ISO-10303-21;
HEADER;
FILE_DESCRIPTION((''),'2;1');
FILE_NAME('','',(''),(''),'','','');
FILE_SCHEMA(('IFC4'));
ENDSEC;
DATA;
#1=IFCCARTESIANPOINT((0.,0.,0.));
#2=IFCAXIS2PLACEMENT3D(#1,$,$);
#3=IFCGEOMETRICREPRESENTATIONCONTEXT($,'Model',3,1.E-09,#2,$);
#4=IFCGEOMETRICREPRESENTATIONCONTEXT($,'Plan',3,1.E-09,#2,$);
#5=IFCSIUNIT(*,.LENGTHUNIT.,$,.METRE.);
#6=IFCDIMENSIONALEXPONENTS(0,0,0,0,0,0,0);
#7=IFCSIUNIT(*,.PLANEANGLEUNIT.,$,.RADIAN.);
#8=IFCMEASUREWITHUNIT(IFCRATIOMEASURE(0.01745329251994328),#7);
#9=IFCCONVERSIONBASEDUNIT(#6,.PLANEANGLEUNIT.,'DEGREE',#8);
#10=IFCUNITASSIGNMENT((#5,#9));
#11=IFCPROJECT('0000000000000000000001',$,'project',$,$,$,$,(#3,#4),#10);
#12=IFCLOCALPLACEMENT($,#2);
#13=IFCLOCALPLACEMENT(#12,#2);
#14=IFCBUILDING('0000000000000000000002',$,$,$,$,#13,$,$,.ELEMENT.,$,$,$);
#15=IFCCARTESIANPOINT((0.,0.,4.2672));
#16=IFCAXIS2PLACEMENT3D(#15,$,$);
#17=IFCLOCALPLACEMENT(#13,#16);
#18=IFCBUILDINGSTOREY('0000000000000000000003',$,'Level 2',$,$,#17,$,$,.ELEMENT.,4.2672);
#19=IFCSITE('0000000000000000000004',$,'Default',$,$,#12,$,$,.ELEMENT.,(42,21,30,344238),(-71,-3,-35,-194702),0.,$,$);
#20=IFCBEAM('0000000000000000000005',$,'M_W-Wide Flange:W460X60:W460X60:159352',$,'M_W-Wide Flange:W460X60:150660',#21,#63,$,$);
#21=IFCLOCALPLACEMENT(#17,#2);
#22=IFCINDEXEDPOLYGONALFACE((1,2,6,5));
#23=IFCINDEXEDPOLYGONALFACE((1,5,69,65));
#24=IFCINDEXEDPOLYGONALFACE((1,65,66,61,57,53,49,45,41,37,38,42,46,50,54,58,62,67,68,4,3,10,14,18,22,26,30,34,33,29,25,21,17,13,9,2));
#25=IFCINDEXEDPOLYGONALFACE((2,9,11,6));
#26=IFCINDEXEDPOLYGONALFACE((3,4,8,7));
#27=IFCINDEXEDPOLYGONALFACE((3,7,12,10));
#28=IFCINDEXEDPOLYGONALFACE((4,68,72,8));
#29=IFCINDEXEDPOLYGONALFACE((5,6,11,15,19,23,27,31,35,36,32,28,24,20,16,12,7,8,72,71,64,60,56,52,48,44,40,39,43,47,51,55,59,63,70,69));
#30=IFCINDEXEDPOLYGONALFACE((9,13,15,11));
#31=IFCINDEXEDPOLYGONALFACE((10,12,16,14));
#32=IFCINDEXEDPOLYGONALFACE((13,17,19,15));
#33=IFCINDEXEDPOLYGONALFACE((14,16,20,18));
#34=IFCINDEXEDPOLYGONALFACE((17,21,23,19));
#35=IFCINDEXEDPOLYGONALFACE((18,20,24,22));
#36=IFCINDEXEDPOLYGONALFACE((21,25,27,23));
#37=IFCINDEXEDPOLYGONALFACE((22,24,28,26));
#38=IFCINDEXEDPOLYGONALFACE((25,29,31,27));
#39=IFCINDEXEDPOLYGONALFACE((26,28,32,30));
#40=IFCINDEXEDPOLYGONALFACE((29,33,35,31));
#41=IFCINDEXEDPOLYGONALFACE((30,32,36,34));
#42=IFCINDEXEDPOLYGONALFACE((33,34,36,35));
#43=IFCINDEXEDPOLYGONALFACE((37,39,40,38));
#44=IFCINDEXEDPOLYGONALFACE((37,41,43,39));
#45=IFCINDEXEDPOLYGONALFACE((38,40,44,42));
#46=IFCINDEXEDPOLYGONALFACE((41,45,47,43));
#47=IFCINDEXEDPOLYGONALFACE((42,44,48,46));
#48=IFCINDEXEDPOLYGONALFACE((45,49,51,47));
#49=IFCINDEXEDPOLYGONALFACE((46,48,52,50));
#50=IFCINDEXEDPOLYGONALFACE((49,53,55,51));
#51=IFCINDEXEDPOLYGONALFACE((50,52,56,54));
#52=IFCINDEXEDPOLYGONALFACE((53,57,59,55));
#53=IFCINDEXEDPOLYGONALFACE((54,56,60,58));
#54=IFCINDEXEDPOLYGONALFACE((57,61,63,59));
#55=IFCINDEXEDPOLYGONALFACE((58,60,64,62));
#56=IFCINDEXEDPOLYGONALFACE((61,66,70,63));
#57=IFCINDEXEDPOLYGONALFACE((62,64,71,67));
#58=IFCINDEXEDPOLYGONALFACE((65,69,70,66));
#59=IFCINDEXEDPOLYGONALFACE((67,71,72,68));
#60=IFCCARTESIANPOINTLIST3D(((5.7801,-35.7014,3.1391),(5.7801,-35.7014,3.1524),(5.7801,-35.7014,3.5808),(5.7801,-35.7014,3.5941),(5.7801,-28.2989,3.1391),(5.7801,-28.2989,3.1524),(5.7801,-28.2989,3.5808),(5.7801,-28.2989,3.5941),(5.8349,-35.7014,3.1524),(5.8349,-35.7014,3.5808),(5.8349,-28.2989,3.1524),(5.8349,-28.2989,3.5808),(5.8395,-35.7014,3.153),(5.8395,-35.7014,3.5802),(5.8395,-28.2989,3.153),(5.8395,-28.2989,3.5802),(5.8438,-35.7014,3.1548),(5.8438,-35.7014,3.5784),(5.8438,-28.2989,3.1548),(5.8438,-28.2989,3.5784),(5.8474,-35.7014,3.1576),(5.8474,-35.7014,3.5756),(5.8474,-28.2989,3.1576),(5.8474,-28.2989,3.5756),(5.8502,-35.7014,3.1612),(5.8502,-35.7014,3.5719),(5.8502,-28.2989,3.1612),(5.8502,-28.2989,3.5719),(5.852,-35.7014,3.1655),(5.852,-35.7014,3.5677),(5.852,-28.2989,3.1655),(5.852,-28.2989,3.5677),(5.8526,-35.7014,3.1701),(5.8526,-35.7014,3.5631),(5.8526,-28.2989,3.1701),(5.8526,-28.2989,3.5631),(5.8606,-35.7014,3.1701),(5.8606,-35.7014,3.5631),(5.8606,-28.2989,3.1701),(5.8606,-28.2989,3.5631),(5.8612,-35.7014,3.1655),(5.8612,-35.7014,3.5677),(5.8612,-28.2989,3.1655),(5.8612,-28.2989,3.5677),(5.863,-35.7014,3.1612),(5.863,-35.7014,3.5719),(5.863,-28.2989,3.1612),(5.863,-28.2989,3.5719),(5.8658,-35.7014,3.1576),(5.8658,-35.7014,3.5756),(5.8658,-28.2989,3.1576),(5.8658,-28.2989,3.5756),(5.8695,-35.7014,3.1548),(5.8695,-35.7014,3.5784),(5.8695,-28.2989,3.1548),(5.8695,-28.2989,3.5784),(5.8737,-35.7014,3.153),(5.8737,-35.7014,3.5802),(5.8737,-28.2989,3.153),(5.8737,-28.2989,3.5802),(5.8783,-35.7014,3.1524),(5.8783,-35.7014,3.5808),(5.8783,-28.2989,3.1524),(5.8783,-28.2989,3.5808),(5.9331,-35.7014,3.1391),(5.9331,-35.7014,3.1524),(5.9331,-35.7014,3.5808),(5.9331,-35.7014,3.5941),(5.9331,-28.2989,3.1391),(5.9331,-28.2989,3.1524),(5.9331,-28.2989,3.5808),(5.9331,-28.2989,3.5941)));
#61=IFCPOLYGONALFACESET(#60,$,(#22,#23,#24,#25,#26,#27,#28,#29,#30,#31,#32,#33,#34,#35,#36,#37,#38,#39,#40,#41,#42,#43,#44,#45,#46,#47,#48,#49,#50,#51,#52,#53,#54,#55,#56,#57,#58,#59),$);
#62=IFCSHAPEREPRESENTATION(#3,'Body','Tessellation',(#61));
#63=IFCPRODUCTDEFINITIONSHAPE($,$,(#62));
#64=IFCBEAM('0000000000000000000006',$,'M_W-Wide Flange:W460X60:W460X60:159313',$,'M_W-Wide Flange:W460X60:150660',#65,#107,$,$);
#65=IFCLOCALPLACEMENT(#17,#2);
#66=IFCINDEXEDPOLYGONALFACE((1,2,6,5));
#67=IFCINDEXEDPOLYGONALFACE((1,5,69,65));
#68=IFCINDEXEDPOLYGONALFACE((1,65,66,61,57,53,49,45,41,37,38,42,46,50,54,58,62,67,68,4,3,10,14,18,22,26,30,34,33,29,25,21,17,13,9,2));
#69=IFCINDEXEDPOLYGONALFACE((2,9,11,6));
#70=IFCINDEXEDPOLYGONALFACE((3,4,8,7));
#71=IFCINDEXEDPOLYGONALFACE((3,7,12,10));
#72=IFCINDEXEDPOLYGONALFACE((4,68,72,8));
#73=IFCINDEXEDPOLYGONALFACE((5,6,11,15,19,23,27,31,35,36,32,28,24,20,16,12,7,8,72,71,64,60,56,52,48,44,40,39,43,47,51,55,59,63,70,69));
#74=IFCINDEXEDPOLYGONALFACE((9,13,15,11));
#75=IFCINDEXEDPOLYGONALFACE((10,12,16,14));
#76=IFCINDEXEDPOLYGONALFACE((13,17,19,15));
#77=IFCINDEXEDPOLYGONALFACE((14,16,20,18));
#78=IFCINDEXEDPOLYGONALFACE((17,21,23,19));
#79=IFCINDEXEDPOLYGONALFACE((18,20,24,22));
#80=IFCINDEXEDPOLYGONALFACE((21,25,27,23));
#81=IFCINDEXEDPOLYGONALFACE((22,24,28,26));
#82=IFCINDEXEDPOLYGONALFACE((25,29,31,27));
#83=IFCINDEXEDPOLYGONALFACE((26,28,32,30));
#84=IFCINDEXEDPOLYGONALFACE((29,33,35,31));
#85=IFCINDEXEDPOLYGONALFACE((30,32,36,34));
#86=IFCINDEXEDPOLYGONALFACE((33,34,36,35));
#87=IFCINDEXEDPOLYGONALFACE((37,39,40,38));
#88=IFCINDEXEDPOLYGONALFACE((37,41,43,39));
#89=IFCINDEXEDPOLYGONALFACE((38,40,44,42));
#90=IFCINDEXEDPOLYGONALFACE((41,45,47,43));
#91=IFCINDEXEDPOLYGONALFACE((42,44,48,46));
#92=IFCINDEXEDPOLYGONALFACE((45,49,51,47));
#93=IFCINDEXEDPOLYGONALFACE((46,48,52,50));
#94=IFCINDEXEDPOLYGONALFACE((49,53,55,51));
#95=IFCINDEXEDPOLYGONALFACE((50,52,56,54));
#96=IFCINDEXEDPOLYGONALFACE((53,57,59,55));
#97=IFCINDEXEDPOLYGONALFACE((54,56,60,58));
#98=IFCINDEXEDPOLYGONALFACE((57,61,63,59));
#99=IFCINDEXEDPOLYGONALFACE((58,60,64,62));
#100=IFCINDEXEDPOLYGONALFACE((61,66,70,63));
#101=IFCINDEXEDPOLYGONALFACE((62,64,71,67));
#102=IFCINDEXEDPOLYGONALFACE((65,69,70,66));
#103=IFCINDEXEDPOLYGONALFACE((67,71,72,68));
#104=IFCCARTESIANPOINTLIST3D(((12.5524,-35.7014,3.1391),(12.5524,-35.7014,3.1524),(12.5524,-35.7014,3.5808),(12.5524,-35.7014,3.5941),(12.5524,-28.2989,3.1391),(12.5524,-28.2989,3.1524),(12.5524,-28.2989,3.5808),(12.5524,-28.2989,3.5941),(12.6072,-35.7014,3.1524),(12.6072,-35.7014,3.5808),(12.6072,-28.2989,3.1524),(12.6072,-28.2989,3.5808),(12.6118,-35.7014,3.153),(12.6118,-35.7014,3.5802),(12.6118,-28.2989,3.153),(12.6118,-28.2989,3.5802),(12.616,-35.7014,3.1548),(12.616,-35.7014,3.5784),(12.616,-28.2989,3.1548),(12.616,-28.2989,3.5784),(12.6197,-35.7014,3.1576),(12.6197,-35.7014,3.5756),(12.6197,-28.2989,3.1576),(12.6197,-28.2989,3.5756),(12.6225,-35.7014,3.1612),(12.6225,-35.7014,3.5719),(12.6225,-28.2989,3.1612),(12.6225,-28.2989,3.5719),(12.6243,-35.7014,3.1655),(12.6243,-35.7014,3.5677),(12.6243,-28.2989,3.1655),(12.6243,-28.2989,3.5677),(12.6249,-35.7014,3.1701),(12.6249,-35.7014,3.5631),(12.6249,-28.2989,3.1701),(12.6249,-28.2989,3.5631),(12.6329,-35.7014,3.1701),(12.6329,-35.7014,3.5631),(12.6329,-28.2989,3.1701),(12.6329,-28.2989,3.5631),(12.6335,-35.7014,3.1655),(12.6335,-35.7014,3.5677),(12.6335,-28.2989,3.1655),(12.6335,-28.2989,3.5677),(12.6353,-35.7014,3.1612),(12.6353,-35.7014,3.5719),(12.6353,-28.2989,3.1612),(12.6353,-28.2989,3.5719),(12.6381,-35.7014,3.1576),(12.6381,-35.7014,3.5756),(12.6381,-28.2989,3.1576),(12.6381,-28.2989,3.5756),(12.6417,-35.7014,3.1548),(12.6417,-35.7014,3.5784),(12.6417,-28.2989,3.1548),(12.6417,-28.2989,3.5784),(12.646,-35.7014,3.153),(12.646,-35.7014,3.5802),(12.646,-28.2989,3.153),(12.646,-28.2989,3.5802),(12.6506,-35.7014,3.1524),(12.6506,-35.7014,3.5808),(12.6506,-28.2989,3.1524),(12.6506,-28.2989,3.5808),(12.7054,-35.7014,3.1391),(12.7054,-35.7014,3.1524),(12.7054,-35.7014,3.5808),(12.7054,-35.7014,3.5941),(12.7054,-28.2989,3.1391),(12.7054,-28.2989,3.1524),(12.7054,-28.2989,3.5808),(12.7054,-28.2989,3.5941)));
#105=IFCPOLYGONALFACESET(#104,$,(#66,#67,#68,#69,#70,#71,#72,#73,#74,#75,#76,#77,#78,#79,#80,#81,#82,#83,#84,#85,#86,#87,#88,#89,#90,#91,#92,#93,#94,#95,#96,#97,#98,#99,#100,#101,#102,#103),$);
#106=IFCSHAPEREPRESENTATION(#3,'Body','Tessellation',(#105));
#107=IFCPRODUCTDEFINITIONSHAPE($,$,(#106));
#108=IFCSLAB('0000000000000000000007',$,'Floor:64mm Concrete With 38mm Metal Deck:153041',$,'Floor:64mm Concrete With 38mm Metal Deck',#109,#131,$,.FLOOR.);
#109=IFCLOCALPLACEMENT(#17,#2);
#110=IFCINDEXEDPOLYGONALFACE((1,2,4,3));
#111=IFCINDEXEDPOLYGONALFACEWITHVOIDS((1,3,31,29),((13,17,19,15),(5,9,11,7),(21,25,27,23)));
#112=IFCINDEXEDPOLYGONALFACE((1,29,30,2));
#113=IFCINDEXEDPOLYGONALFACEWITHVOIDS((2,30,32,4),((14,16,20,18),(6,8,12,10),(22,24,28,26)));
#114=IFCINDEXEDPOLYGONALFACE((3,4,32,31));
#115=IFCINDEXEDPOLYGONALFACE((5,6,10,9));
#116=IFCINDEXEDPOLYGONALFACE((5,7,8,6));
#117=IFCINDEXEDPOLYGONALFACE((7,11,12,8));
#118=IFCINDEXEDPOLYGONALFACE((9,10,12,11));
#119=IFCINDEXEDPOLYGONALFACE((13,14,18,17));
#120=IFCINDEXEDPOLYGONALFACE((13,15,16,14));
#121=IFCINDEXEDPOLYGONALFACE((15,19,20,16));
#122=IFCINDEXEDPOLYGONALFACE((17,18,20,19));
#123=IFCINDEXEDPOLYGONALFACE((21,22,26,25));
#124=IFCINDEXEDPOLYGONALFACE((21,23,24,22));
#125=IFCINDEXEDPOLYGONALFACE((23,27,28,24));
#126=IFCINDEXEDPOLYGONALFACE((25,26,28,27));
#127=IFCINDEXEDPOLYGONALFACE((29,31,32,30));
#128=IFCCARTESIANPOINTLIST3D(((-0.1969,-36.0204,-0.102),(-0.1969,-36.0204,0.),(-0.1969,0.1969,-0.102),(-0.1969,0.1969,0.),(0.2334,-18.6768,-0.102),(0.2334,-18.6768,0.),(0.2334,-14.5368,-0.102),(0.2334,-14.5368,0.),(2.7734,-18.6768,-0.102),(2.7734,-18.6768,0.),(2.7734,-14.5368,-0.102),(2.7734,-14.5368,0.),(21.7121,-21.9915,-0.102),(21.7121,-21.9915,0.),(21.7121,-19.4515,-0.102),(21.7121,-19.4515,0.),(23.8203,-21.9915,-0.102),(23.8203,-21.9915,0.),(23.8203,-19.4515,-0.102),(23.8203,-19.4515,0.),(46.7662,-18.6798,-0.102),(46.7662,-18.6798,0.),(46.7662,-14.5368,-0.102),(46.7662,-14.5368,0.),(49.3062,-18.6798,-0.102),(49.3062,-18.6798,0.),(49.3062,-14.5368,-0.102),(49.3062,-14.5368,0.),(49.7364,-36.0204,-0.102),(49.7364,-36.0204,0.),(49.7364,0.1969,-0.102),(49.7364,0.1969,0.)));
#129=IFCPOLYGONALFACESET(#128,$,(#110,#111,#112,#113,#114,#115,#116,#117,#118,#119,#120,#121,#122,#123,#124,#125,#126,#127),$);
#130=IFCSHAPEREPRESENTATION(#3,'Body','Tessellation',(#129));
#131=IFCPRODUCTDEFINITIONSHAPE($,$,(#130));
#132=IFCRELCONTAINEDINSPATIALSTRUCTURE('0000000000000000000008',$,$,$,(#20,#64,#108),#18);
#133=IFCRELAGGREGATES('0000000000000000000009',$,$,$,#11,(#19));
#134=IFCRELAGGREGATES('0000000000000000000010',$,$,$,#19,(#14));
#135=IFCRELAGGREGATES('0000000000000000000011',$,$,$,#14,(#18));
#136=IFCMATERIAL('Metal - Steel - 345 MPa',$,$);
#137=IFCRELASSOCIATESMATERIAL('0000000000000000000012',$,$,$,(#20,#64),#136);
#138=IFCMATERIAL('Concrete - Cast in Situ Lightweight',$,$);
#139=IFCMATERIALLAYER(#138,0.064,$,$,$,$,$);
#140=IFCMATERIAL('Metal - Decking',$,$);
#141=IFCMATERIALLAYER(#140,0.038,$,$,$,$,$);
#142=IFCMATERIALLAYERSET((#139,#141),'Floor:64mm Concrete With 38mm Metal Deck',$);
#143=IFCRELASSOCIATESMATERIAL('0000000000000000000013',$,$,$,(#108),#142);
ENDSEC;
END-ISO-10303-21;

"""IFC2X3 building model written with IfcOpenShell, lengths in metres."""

from ifc_helpers import new_model, entity, si_unit, converted_unit, frame, frame_2d, origin, origin_2d_with_axis, place, context, project, spatial, polyline, circle_curve, parameter, trimmed, segment, composite_curve, rectangle, outline, extrude, material, layer, layer_set, layer_usage, element, save


model = new_model("IFC2X3")

# Units and contexts
model_context = context("Model", 3, precision=1e-09, world=origin())
plan_context = context("Plan", 3, precision=1e-09, world=origin())
ifc_project = project(units=[si_unit("LENGTHUNIT", "METRE"), converted_unit("PLANEANGLEUNIT", "DEGREE", entity("IfcRatioMeasure", 0.01745329251994328), si_unit("PLANEANGLEUNIT", "RADIAN"), dimensions=[0, 0, 0, 0, 0, 0, 0])], contexts=[model_context, plan_context])

# Site, building, storey
site_placement = place(None, origin())
site = spatial("IfcSite", under=ifc_project, at=site_placement, Name="Default", CompositionType="ELEMENT", RefLatitude=(42, 21, 30, 344238), RefLongitude=(-71, -3, -35, -194702), RefElevation=0.0)
building_placement = place(site_placement, origin())
building = spatial("IfcBuilding", under=site, at=building_placement, CompositionType="ELEMENT")
storey_placement = place(building_placement, frame((0.0, 0.0, 4.2672)))
storey = spatial("IfcBuildingStorey", under=building, at=storey_placement, Name="Level 2", CompositionType="ELEMENT", Elevation=4.2672)

# Shared definitions
ifc_material_1 = material(Name="Metal - Steel - 345 MPa")

# Beams
beam_1_placement = place(storey_placement, frame((5.8566, -35.8299, 3.6576)))
element("IfcBeam", 1, at=beam_1_placement, inside=storey, material=ifc_material_1, Name="M_W-Wide Flange:W460X60:W460X60:159352", ObjectType="M_W-Wide Flange:W460X60:150660", context=model_context, shape_type="SweptSolid", body=[
    extrude(outline(composite_curve([segment(polyline([(-0.0765, -0.2142), (-0.0765, -0.2275)]), True, "CONTINUOUS"), segment(polyline([(-0.0765, -0.2275), (0.0765, -0.2275)]), True, "CONTINUOUS"), segment(polyline([(0.0765, -0.2275), (0.0765, -0.2142)]), True, "CONTINUOUS"), segment(polyline([(0.0765, -0.2142), (0.0217, -0.2142)]), True, "CONTINUOUS"), segment(trimmed(circle_curve(frame_2d((0.0217, -0.1965), x_axis=(0.0, -1.0)), 0.0177), [parameter(270.0)], [parameter(360.0)], True, "PARAMETER"), False, "CONTINUOUS"), segment(polyline([(0.004, -0.1965), (0.004, 0.1965)]), True, "CONTINUOUS"), segment(trimmed(circle_curve(frame_2d((0.0217, 0.1965), x_axis=(-1.0, 0.0)), 0.0177), [parameter(270.0)], [parameter(360.0)], True, "PARAMETER"), False, "CONTINUOUS"), segment(polyline([(0.0217, 0.2142), (0.0765, 0.2142)]), True, "CONTINUOUS"), segment(polyline([(0.0765, 0.2142), (0.0765, 0.2275)]), True, "CONTINUOUS"), segment(polyline([(0.0765, 0.2275), (-0.0765, 0.2275)]), True, "CONTINUOUS"), segment(polyline([(-0.0765, 0.2275), (-0.0765, 0.2142)]), True, "CONTINUOUS"), segment(polyline([(-0.0765, 0.2142), (-0.0217, 0.2142)]), True, "CONTINUOUS"), segment(trimmed(circle_curve(frame_2d((-0.0217, 0.1965), x_axis=(0.0, 1.0)), 0.0177), [parameter(270.0)], [parameter(360.0)], True, "PARAMETER"), False, "CONTINUOUS"), segment(polyline([(-0.004, 0.1965), (-0.004, -0.1965)]), True, "CONTINUOUS"), segment(trimmed(circle_curve(frame_2d((-0.0217, -0.1965), x_axis=(1.0, 0.0)), 0.0177), [parameter(270.0)], [parameter(0.0)], True, "PARAMETER"), False, "CONTINUOUS"), segment(polyline([(-0.0217, -0.2142), (-0.0765, -0.2142)]), True, "CONTINUOUS")], self_intersect=False)), frame((0.0, 0.1285, -0.291), z_axis=(0.0, -1.0, 0.0), x_axis=(1.0, 0.0, 0.0)), (0.0, 0.0, -1.0), 7.4025),
])
beam_2_placement = place(storey_placement, frame((12.6289, -35.8299, 3.6576)))
element("IfcBeam", 2, at=beam_2_placement, inside=storey, material=ifc_material_1, Name="M_W-Wide Flange:W460X60:W460X60:159313", ObjectType="M_W-Wide Flange:W460X60:150660", context=model_context, shape_type="SweptSolid", body=[
    extrude(outline(composite_curve([segment(polyline([(-0.0765, -0.2142), (-0.0765, -0.2275)]), True, "CONTINUOUS"), segment(polyline([(-0.0765, -0.2275), (0.0765, -0.2275)]), True, "CONTINUOUS"), segment(polyline([(0.0765, -0.2275), (0.0765, -0.2142)]), True, "CONTINUOUS"), segment(polyline([(0.0765, -0.2142), (0.0217, -0.2142)]), True, "CONTINUOUS"), segment(trimmed(circle_curve(frame_2d((0.0217, -0.1965), x_axis=(0.0, -1.0)), 0.0177), [parameter(270.0)], [parameter(360.0)], True, "PARAMETER"), False, "CONTINUOUS"), segment(polyline([(0.004, -0.1965), (0.004, 0.1965)]), True, "CONTINUOUS"), segment(trimmed(circle_curve(frame_2d((0.0217, 0.1965), x_axis=(-1.0, 0.0)), 0.0177), [parameter(270.0)], [parameter(360.0)], True, "PARAMETER"), False, "CONTINUOUS"), segment(polyline([(0.0217, 0.2142), (0.0765, 0.2142)]), True, "CONTINUOUS"), segment(polyline([(0.0765, 0.2142), (0.0765, 0.2275)]), True, "CONTINUOUS"), segment(polyline([(0.0765, 0.2275), (-0.0765, 0.2275)]), True, "CONTINUOUS"), segment(polyline([(-0.0765, 0.2275), (-0.0765, 0.2142)]), True, "CONTINUOUS"), segment(polyline([(-0.0765, 0.2142), (-0.0217, 0.2142)]), True, "CONTINUOUS"), segment(trimmed(circle_curve(frame_2d((-0.0217, 0.1965), x_axis=(0.0, 1.0)), 0.0177), [parameter(270.0)], [parameter(360.0)], True, "PARAMETER"), False, "CONTINUOUS"), segment(polyline([(-0.004, 0.1965), (-0.004, -0.1965)]), True, "CONTINUOUS"), segment(trimmed(circle_curve(frame_2d((-0.0217, -0.1965), x_axis=(1.0, 0.0)), 0.0177), [parameter(270.0)], [parameter(0.0)], True, "PARAMETER"), False, "CONTINUOUS"), segment(polyline([(-0.0217, -0.2142), (-0.0765, -0.2142)]), True, "CONTINUOUS")], self_intersect=False)), frame((0.0, 0.1285, -0.291), z_axis=(0.0, -1.0, 0.0), x_axis=(1.0, 0.0, 0.0)), (0.0, 0.0, -1.0), 7.4025),
])

# Slab, openings
ifc_material_2 = material(Name="Concrete - Cast in Situ Lightweight")
ifc_layer_1 = layer(ifc_material_2, 0.064)
ifc_material_3 = material(Name="Metal - Decking")
ifc_layer_2 = layer(ifc_material_3, 0.038)
ifc_layer_set = layer_set([ifc_layer_1, ifc_layer_2], Name="Floor:64mm Concrete With 38mm Metal Deck")
ifc_layer_usage = layer_usage(ifc_layer_set, "AXIS3", "POSITIVE", 0.0)
slab_placement = place(storey_placement, frame((-0.1969, -36.0204, -0.102)))
slab = element("IfcSlab", 3, at=slab_placement, inside=storey, material=ifc_layer_usage, Name="Floor:64mm Concrete With 38mm Metal Deck:153041", ObjectType="Floor:64mm Concrete With 38mm Metal Deck", PredefinedType="FLOOR", context=model_context, shape_type="SweptSolid", body=[
    extrude(rectangle(XDim=36.2173, YDim=49.9333, at=frame_2d((0.0, 0.0), x_axis=(0.0, -1.0))), frame((24.9667, 18.1087, 0.102), z_axis=(0.0, 0.0, -1.0), x_axis=(-1.0, 0.0, 0.0)), (0.0, 0.0, 1.0), 0.102),
])
opening_1_placement = place(slab_placement, frame((22.963, 15.299, 0.102)))
element("IfcOpeningElement", 4, at=opening_1_placement, cuts=slab, ObjectType="Opening", context=model_context, shape_type="SweptSolid", body=[
    extrude(rectangle(XDim=2.1082, YDim=2.54, at=origin_2d_with_axis()), frame((0.0, 0.0, 0.0), z_axis=(0.0, 0.0, -1.0), x_axis=(1.0, 0.0, 0.0)), (0.0, 0.0, 1.0), 0.102),
])
opening_2_placement = place(slab_placement, frame((1.7002, 19.4137, 0.102)))
element("IfcOpeningElement", 5, at=opening_2_placement, cuts=slab, ObjectType="Opening", context=model_context, shape_type="SweptSolid", body=[
    extrude(rectangle(XDim=4.14, YDim=2.54, at=origin_2d_with_axis()), frame((0.0, 0.0, 0.0), z_axis=(0.0, 0.0, -1.0), x_axis=(0.0, 1.0, 0.0)), (0.0, 0.0, 1.0), 0.102),
])
opening_3_placement = place(slab_placement, frame((48.2331, 19.4121, 0.102)))
element("IfcOpeningElement", 6, at=opening_3_placement, cuts=slab, ObjectType="Opening", context=model_context, shape_type="SweptSolid", body=[
    extrude(rectangle(XDim=2.54, YDim=4.1431, at=origin_2d_with_axis()), frame((0.0, 0.0, 0.0), z_axis=(0.0, 0.0, -1.0), x_axis=(-1.0, 0.0, 0.0)), (0.0, 0.0, 1.0), 0.102),
])

save(model, "model.ifc")
